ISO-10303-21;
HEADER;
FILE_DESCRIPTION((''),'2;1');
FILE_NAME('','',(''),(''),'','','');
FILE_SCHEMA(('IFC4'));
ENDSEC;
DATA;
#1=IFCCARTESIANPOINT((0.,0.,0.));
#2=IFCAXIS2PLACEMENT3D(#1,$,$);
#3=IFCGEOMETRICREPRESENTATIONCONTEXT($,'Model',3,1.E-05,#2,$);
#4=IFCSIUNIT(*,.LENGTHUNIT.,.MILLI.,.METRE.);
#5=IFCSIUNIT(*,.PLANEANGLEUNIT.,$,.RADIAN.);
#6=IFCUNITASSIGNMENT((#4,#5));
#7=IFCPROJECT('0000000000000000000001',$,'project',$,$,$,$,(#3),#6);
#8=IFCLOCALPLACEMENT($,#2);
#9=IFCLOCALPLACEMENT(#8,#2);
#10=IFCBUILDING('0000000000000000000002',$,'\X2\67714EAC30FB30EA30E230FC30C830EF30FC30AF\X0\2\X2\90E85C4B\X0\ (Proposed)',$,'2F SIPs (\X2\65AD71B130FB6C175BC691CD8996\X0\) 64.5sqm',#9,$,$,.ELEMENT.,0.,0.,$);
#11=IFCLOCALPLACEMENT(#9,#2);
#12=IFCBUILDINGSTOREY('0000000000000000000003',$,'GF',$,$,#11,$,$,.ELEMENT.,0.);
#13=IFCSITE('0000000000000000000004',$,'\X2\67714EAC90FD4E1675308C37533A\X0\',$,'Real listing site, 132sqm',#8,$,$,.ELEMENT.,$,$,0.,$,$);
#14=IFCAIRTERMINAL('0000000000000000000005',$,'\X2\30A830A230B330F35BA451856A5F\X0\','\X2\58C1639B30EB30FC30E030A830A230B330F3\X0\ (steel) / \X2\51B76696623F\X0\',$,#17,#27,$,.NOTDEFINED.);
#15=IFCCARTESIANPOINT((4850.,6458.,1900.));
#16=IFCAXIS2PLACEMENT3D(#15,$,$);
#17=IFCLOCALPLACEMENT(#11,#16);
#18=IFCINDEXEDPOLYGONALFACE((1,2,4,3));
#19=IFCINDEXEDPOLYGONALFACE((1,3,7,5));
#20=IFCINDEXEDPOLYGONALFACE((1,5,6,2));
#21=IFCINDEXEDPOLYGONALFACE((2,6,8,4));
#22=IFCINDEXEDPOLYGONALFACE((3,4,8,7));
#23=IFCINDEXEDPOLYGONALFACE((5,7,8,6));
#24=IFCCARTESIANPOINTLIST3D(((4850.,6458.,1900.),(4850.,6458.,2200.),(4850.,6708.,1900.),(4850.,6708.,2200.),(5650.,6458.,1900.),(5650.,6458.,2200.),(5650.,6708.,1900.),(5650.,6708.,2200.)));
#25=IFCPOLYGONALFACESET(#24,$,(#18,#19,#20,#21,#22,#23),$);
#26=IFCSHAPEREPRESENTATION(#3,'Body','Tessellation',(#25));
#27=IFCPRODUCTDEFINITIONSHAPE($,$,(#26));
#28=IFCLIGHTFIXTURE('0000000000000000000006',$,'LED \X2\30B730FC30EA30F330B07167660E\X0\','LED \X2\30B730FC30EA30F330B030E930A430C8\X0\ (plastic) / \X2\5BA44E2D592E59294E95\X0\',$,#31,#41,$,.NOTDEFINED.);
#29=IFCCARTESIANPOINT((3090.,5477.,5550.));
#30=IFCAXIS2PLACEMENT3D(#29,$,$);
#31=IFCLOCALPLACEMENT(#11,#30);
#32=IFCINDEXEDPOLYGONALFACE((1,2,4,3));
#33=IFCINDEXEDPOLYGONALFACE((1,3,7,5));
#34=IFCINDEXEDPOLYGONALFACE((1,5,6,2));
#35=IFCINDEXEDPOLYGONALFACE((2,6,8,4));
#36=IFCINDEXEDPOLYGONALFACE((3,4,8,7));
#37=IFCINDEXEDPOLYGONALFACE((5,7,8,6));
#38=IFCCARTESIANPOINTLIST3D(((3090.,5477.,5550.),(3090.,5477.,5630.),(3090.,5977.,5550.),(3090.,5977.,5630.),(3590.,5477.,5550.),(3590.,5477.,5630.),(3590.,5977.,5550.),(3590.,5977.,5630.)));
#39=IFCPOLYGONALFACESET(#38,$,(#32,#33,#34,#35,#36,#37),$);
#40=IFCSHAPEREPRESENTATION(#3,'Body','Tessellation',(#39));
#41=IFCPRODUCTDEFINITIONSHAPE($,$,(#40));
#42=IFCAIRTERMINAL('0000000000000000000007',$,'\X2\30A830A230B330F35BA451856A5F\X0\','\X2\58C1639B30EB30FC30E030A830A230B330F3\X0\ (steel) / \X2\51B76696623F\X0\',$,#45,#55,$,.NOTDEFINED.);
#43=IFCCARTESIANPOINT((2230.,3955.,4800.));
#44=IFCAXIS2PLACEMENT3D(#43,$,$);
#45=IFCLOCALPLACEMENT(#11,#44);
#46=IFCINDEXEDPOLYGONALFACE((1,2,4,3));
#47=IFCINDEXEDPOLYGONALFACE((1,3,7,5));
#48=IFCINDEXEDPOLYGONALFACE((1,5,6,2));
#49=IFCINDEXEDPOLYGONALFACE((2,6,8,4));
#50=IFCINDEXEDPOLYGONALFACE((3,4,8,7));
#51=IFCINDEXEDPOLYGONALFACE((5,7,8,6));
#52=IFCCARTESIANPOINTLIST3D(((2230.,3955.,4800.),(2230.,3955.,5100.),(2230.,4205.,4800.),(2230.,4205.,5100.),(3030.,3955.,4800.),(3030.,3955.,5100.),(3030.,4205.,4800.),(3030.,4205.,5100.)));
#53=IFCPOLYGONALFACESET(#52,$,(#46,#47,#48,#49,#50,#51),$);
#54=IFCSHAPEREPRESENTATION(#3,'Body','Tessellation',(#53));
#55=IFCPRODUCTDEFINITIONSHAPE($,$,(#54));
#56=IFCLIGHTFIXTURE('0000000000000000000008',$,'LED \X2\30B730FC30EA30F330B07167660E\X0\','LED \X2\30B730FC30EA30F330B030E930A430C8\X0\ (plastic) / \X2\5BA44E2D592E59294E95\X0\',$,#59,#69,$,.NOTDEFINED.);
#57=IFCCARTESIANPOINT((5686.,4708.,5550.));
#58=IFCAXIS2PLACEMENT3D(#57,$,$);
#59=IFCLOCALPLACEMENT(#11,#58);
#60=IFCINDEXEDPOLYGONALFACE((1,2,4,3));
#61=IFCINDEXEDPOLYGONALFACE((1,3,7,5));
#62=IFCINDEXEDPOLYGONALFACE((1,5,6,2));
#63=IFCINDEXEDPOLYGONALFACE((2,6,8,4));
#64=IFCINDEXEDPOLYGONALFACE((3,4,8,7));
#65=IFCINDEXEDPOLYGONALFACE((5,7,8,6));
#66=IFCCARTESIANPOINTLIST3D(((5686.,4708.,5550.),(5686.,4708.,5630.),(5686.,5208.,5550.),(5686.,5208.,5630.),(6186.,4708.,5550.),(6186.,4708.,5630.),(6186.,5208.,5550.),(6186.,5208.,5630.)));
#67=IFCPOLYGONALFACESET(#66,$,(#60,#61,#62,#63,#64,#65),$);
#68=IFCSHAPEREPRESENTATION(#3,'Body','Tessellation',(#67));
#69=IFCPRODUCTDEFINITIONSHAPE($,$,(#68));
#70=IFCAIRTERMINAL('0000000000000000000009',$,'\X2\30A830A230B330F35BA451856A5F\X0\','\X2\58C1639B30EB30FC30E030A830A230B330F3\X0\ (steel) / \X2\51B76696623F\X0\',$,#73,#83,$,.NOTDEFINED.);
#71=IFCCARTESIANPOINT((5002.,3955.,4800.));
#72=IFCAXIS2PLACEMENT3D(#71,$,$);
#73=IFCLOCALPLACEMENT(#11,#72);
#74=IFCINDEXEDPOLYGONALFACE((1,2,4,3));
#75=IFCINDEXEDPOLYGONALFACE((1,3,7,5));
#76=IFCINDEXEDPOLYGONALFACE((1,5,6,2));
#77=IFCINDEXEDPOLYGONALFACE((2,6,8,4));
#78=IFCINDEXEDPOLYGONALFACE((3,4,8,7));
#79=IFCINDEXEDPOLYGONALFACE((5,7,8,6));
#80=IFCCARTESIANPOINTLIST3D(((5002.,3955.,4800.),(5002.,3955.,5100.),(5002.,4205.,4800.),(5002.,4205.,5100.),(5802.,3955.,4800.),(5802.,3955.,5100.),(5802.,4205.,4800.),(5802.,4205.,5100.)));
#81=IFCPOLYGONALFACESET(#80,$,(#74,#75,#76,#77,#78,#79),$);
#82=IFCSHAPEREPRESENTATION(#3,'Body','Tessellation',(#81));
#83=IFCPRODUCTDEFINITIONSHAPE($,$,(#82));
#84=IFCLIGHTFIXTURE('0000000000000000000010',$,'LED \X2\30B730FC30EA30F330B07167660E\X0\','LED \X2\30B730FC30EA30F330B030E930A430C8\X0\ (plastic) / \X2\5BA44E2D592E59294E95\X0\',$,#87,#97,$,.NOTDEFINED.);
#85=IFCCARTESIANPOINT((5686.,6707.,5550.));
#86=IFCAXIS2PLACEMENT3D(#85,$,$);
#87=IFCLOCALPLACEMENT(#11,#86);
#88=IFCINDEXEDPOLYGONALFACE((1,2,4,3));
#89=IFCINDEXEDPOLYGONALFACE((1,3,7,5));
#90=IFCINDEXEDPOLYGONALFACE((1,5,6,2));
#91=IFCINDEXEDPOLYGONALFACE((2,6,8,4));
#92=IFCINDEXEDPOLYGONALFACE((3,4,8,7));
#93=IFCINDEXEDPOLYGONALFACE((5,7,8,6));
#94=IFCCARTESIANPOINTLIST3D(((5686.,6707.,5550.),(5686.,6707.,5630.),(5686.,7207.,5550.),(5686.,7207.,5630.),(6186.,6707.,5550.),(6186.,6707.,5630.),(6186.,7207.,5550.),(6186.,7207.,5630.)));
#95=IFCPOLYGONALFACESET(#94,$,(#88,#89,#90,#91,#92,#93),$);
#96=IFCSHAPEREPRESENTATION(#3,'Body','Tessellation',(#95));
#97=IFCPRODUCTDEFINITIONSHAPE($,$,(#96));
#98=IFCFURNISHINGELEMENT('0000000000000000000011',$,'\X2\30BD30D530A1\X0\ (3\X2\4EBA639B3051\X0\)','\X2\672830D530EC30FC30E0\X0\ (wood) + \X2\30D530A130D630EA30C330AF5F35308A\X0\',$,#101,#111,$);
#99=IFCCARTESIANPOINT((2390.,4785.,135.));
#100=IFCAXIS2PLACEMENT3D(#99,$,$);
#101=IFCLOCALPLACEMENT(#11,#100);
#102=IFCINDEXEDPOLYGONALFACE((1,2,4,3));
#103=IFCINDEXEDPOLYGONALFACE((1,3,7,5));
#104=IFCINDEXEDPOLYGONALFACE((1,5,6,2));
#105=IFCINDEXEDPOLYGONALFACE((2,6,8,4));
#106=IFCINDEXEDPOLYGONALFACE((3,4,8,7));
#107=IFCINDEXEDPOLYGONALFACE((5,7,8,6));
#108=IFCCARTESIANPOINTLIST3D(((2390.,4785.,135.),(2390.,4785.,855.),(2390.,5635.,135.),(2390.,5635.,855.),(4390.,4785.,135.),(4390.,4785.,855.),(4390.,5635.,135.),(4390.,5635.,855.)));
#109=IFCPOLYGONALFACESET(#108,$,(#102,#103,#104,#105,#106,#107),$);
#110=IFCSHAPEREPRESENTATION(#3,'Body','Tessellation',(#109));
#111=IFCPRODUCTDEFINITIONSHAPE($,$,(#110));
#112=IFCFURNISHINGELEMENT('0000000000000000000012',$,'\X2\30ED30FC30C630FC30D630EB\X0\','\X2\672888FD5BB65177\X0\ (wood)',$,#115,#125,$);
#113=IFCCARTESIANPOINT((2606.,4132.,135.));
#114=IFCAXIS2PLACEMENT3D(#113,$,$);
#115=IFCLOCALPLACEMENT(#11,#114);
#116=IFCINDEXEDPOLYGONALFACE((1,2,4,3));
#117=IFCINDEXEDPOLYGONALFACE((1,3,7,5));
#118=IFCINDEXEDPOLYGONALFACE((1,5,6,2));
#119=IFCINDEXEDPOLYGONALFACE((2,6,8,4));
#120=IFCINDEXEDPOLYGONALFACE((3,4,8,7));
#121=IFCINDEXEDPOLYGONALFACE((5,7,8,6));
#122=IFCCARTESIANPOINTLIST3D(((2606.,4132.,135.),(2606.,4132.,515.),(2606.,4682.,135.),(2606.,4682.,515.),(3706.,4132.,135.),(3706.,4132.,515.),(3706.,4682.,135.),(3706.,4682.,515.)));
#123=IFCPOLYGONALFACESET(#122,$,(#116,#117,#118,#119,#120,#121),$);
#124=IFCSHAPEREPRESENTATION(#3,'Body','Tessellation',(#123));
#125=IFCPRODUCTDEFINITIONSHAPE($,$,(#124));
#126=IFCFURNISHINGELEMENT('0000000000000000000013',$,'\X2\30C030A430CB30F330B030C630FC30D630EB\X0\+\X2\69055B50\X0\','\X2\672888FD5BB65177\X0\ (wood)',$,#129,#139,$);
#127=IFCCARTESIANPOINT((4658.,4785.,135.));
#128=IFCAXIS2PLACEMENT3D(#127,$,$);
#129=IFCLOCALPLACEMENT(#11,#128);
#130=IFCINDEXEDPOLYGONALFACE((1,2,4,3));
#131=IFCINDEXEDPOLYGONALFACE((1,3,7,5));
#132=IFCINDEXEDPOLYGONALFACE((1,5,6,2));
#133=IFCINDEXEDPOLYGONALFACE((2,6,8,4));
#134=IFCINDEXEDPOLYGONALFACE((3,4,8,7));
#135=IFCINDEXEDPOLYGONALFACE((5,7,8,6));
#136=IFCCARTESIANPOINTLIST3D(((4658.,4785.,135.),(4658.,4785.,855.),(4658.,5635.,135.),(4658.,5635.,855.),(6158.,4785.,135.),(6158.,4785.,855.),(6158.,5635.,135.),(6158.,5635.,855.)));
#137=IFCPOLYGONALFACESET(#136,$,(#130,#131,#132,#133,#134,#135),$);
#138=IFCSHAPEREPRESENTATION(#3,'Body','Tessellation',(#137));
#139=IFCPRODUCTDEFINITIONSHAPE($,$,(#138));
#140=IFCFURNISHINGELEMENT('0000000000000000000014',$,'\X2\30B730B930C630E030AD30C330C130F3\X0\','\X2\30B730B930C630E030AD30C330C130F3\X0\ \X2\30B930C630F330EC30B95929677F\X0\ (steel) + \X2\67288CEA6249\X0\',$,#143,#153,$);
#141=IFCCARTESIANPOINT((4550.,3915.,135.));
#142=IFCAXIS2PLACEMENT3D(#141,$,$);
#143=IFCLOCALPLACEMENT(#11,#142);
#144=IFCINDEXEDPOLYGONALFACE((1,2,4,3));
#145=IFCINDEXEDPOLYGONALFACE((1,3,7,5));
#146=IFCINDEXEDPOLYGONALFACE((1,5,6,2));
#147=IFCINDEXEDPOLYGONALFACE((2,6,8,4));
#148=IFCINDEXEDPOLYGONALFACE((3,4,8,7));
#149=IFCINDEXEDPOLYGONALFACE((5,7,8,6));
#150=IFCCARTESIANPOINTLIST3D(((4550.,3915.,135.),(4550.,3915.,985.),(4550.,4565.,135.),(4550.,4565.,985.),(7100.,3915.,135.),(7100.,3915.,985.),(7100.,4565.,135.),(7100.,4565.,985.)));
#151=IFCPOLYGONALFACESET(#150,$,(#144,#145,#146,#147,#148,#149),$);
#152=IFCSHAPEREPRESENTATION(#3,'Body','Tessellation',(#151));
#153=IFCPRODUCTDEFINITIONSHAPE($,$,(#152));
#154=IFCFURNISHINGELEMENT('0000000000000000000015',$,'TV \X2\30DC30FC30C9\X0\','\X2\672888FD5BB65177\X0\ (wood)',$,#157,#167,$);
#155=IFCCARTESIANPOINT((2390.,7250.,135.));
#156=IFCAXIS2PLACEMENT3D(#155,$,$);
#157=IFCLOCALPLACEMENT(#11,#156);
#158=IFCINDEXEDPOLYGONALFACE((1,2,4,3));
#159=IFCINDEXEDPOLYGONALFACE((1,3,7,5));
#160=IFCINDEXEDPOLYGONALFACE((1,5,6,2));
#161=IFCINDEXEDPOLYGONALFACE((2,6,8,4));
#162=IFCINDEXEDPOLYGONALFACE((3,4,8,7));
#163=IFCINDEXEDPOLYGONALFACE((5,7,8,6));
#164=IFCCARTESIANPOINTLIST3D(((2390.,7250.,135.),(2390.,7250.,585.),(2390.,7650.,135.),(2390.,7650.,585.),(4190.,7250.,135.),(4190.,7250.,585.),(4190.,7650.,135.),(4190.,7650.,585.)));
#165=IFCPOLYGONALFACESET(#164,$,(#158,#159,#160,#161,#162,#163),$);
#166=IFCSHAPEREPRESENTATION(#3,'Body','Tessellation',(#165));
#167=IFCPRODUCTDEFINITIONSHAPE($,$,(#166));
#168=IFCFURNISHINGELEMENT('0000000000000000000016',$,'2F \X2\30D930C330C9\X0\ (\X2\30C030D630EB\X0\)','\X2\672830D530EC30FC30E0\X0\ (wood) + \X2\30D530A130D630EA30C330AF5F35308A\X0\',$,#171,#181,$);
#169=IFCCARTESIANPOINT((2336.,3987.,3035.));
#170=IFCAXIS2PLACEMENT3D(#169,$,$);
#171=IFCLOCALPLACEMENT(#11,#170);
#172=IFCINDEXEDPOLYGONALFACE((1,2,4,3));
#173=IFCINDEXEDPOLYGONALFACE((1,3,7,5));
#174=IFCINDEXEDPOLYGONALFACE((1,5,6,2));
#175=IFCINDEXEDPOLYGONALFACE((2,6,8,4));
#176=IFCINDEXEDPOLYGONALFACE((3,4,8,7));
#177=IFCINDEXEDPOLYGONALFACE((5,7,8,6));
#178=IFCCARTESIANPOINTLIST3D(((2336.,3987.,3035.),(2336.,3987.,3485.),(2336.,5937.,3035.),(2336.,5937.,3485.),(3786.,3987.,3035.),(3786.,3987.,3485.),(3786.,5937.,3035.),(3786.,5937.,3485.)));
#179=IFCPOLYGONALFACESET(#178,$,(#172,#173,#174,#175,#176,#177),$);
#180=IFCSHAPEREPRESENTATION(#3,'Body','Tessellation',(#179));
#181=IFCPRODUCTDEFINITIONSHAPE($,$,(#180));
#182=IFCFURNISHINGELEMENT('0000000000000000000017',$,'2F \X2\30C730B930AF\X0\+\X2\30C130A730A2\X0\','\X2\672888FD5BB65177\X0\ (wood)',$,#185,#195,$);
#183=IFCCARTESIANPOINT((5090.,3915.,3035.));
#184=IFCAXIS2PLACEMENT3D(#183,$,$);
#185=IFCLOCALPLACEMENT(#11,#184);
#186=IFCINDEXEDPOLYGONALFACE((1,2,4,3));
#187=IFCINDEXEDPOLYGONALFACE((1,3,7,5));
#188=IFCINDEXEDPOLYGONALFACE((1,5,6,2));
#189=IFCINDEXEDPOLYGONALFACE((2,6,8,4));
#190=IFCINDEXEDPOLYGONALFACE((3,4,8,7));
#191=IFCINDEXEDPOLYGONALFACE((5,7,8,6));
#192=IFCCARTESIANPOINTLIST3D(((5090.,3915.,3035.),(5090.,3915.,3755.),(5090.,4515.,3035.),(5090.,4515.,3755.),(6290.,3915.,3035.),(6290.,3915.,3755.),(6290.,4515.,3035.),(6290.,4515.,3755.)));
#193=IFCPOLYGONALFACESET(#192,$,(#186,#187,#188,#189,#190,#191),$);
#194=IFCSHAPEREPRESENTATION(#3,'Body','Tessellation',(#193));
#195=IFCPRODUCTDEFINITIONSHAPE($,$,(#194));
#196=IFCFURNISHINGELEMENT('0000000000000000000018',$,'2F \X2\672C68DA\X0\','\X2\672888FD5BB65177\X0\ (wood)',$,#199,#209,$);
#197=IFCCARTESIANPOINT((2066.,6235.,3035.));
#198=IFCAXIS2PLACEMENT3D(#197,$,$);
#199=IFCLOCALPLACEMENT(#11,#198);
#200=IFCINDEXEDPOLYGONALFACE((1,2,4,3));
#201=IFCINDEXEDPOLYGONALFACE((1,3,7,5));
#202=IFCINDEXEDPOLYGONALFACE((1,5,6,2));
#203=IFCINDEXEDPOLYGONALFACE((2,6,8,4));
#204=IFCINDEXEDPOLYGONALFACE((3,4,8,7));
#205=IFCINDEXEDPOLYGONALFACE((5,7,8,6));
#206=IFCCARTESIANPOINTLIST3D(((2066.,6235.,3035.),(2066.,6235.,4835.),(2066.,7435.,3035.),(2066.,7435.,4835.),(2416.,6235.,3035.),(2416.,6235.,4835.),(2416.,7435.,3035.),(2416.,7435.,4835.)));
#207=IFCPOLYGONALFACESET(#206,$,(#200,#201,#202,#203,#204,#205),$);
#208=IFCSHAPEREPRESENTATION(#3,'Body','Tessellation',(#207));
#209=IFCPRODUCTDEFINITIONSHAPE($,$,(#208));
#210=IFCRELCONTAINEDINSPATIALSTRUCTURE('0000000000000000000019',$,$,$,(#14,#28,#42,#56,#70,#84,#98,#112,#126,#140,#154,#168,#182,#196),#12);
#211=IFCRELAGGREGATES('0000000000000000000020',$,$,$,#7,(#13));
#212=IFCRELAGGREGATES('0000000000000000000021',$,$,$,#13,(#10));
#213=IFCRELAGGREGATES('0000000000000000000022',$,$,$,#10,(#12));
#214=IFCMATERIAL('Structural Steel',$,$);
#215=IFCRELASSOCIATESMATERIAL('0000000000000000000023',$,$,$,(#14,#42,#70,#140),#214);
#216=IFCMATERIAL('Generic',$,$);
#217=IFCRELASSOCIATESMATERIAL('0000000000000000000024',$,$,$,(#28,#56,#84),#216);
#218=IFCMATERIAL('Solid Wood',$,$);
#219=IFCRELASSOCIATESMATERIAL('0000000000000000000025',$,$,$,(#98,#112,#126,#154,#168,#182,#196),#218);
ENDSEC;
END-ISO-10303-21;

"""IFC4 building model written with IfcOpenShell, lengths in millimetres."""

from ifc_helpers import new_model, si_unit, frame, frame_2d, origin, place, context, project, spatial, rectangle, extrude, material, element, save


model = new_model("IFC4")

# Units and contexts
model_context = context("Model", 3, precision=1e-05, world=origin())
ifc_project = project(units=[si_unit("LENGTHUNIT", "METRE", prefix="MILLI"), si_unit("PLANEANGLEUNIT", "RADIAN")], contexts=[model_context])

# Site, building, storey
site_placement = place(None, origin())
site = spatial("IfcSite", under=ifc_project, at=site_placement, Name="東京都世田谷区", ObjectType="Real listing site, 132sqm", CompositionType="ELEMENT", RefElevation=0.0)
building_placement = place(site_placement, origin())
building = spatial("IfcBuilding", under=site, at=building_placement, Name="東京・リモートワーク2部屋 (Proposed)", ObjectType="2F SIPs (断熱・気密重視) 64.5sqm", CompositionType="ELEMENT", ElevationOfRefHeight=0.0, ElevationOfTerrain=0.0)
storey_placement = place(building_placement, origin())
storey = spatial("IfcBuildingStorey", under=building, at=storey_placement, Name="GF", CompositionType="ELEMENT", Elevation=0.0)

# Shared definitions
ifc_material_1 = material(Name="Solid Wood")

# Shared definitions
ifc_material_2 = material(Name="Structural Steel")

# Shared definitions
ifc_material_3 = material(Name="Generic")

# Air terminal
air_terminal_1_placement = place(storey_placement, frame((4850.0, 6458.0, 1900.0)))
element("IfcAirTerminal", 1, at=air_terminal_1_placement, inside=storey, material=ifc_material_2, Name="エアコン室内機", Description="壁掛ルームエアコン (steel) / 冷暖房", PredefinedType="NOTDEFINED", context=model_context, shape_type="SweptSolid", body=[
    extrude(rectangle(XDim=800.0, YDim=250.0, at=frame_2d((400.0, 125.0))), frame((4850.0, 6458.0, 1900.0)), (0.0, 0.0, 1.0), 300.0),
])

# Light fixture
light_fixture_1_placement = place(storey_placement, frame((3090.0, 5477.0, 5550.0)))
element("IfcLightFixture", 2, at=light_fixture_1_placement, inside=storey, material=ifc_material_3, Name="LED シーリング照明", Description="LED シーリングライト (plastic) / 室中央天井", PredefinedType="NOTDEFINED", context=model_context, shape_type="SweptSolid", body=[
    extrude(rectangle(XDim=500.0, YDim=500.0, at=frame_2d((250.0, 250.0))), frame((3090.0, 5477.0, 5550.0)), (0.0, 0.0, 1.0), 80.0),
])

# Air terminal
air_terminal_2_placement = place(storey_placement, frame((2230.0, 3955.0, 4800.0)))
element("IfcAirTerminal", 3, at=air_terminal_2_placement, inside=storey, material=ifc_material_2, Name="エアコン室内機", Description="壁掛ルームエアコン (steel) / 冷暖房", PredefinedType="NOTDEFINED", context=model_context, shape_type="SweptSolid", body=[
    extrude(rectangle(XDim=800.0, YDim=250.0, at=frame_2d((400.0, 125.0))), frame((2230.0, 3955.0, 4800.0)), (0.0, 0.0, 1.0), 300.0),
])

# Light fixture
light_fixture_2_placement = place(storey_placement, frame((5686.0, 4708.0, 5550.0)))
element("IfcLightFixture", 4, at=light_fixture_2_placement, inside=storey, material=ifc_material_3, Name="LED シーリング照明", Description="LED シーリングライト (plastic) / 室中央天井", PredefinedType="NOTDEFINED", context=model_context, shape_type="SweptSolid", body=[
    extrude(rectangle(XDim=500.0, YDim=500.0, at=frame_2d((250.0, 250.0))), frame((5686.0, 4708.0, 5550.0)), (0.0, 0.0, 1.0), 80.0),
])

# Air terminal
air_terminal_3_placement = place(storey_placement, frame((5002.0, 3955.0, 4800.0)))
element("IfcAirTerminal", 5, at=air_terminal_3_placement, inside=storey, material=ifc_material_2, Name="エアコン室内機", Description="壁掛ルームエアコン (steel) / 冷暖房", PredefinedType="NOTDEFINED", context=model_context, shape_type="SweptSolid", body=[
    extrude(rectangle(XDim=800.0, YDim=250.0, at=frame_2d((400.0, 125.0))), frame((5002.0, 3955.0, 4800.0)), (0.0, 0.0, 1.0), 300.0),
])

# Light fixture
light_fixture_3_placement = place(storey_placement, frame((5686.0, 6707.0, 5550.0)))
element("IfcLightFixture", 6, at=light_fixture_3_placement, inside=storey, material=ifc_material_3, Name="LED シーリング照明", Description="LED シーリングライト (plastic) / 室中央天井", PredefinedType="NOTDEFINED", context=model_context, shape_type="SweptSolid", body=[
    extrude(rectangle(XDim=500.0, YDim=500.0, at=frame_2d((250.0, 250.0))), frame((5686.0, 6707.0, 5550.0)), (0.0, 0.0, 1.0), 80.0),
])

# Furnishing elements
furnishing_1_placement = place(storey_placement, frame((2390.0, 4785.0, 135.0)))
element("IfcFurnishingElement", 7, at=furnishing_1_placement, inside=storey, material=ifc_material_1, Name="ソファ (3人掛け)", Description="木フレーム (wood) + ファブリック張り", context=model_context, shape_type="SweptSolid", body=[
    extrude(rectangle(XDim=2000.0, YDim=850.0, at=frame_2d((1000.0, 425.0))), frame((2390.0, 4785.0, 135.0)), (0.0, 0.0, 1.0), 720.0),
])
furnishing_2_placement = place(storey_placement, frame((2606.0, 4132.0, 135.0)))
element("IfcFurnishingElement", 8, at=furnishing_2_placement, inside=storey, material=ifc_material_1, Name="ローテーブル", Description="木製家具 (wood)", context=model_context, shape_type="SweptSolid", body=[
    extrude(rectangle(XDim=1100.0, YDim=550.0, at=frame_2d((550.0, 275.0))), frame((2606.0, 4132.0, 135.0)), (0.0, 0.0, 1.0), 380.0),
])
furnishing_3_placement = place(storey_placement, frame((4658.0, 4785.0, 135.0)))
element("IfcFurnishingElement", 9, at=furnishing_3_placement, inside=storey, material=ifc_material_1, Name="ダイニングテーブル+椅子", Description="木製家具 (wood)", context=model_context, shape_type="SweptSolid", body=[
    extrude(rectangle(XDim=1500.0, YDim=850.0, at=frame_2d((750.0, 425.0))), frame((4658.0, 4785.0, 135.0)), (0.0, 0.0, 1.0), 720.0),
])
furnishing_4_placement = place(storey_placement, frame((4550.0, 3915.0, 135.0)))
element("IfcFurnishingElement", 10, at=furnishing_4_placement, inside=storey, material=ifc_material_2, Name="システムキッチン", Description="システムキッチン ステンレス天板 (steel) + 木質扉", context=model_context, shape_type="SweptSolid", body=[
    extrude(rectangle(XDim=2550.0, YDim=650.0, at=frame_2d((1275.0, 325.0))), frame((4550.0, 3915.0, 135.0)), (0.0, 0.0, 1.0), 850.0),
])
furnishing_5_placement = place(storey_placement, frame((2390.0, 7250.0, 135.0)))
element("IfcFurnishingElement", 11, at=furnishing_5_placement, inside=storey, material=ifc_material_1, Name="TV ボード", Description="木製家具 (wood)", context=model_context, shape_type="SweptSolid", body=[
    extrude(rectangle(XDim=1800.0, YDim=400.0, at=frame_2d((900.0, 200.0))), frame((2390.0, 7250.0, 135.0)), (0.0, 0.0, 1.0), 450.0),
])
furnishing_6_placement = place(storey_placement, frame((2336.0, 3987.0, 3035.0)))
element("IfcFurnishingElement", 12, at=furnishing_6_placement, inside=storey, material=ifc_material_1, Name="2F ベッド (ダブル)", Description="木フレーム (wood) + ファブリック張り", context=model_context, shape_type="SweptSolid", body=[
    extrude(rectangle(XDim=1450.0, YDim=1950.0, at=frame_2d((725.0, 975.0))), frame((2336.0, 3987.0, 3035.0)), (0.0, 0.0, 1.0), 450.0),
])
furnishing_7_placement = place(storey_placement, frame((5090.0, 3915.0, 3035.0)))
element("IfcFurnishingElement", 13, at=furnishing_7_placement, inside=storey, material=ifc_material_1, Name="2F デスク+チェア", Description="木製家具 (wood)", context=model_context, shape_type="SweptSolid", body=[
    extrude(rectangle(XDim=1200.0, YDim=600.0, at=frame_2d((600.0, 300.0))), frame((5090.0, 3915.0, 3035.0)), (0.0, 0.0, 1.0), 720.0),
])
furnishing_8_placement = place(storey_placement, frame((2066.0, 6235.0, 3035.0)))
element("IfcFurnishingElement", 14, at=furnishing_8_placement, inside=storey, material=ifc_material_1, Name="2F 本棚", Description="木製家具 (wood)", context=model_context, shape_type="SweptSolid", body=[
    extrude(rectangle(XDim=350.0, YDim=1200.0, at=frame_2d((175.0, 600.0))), frame((2066.0, 6235.0, 3035.0)), (0.0, 0.0, 1.0), 1800.0),
])

save(model, "model.ifc")
